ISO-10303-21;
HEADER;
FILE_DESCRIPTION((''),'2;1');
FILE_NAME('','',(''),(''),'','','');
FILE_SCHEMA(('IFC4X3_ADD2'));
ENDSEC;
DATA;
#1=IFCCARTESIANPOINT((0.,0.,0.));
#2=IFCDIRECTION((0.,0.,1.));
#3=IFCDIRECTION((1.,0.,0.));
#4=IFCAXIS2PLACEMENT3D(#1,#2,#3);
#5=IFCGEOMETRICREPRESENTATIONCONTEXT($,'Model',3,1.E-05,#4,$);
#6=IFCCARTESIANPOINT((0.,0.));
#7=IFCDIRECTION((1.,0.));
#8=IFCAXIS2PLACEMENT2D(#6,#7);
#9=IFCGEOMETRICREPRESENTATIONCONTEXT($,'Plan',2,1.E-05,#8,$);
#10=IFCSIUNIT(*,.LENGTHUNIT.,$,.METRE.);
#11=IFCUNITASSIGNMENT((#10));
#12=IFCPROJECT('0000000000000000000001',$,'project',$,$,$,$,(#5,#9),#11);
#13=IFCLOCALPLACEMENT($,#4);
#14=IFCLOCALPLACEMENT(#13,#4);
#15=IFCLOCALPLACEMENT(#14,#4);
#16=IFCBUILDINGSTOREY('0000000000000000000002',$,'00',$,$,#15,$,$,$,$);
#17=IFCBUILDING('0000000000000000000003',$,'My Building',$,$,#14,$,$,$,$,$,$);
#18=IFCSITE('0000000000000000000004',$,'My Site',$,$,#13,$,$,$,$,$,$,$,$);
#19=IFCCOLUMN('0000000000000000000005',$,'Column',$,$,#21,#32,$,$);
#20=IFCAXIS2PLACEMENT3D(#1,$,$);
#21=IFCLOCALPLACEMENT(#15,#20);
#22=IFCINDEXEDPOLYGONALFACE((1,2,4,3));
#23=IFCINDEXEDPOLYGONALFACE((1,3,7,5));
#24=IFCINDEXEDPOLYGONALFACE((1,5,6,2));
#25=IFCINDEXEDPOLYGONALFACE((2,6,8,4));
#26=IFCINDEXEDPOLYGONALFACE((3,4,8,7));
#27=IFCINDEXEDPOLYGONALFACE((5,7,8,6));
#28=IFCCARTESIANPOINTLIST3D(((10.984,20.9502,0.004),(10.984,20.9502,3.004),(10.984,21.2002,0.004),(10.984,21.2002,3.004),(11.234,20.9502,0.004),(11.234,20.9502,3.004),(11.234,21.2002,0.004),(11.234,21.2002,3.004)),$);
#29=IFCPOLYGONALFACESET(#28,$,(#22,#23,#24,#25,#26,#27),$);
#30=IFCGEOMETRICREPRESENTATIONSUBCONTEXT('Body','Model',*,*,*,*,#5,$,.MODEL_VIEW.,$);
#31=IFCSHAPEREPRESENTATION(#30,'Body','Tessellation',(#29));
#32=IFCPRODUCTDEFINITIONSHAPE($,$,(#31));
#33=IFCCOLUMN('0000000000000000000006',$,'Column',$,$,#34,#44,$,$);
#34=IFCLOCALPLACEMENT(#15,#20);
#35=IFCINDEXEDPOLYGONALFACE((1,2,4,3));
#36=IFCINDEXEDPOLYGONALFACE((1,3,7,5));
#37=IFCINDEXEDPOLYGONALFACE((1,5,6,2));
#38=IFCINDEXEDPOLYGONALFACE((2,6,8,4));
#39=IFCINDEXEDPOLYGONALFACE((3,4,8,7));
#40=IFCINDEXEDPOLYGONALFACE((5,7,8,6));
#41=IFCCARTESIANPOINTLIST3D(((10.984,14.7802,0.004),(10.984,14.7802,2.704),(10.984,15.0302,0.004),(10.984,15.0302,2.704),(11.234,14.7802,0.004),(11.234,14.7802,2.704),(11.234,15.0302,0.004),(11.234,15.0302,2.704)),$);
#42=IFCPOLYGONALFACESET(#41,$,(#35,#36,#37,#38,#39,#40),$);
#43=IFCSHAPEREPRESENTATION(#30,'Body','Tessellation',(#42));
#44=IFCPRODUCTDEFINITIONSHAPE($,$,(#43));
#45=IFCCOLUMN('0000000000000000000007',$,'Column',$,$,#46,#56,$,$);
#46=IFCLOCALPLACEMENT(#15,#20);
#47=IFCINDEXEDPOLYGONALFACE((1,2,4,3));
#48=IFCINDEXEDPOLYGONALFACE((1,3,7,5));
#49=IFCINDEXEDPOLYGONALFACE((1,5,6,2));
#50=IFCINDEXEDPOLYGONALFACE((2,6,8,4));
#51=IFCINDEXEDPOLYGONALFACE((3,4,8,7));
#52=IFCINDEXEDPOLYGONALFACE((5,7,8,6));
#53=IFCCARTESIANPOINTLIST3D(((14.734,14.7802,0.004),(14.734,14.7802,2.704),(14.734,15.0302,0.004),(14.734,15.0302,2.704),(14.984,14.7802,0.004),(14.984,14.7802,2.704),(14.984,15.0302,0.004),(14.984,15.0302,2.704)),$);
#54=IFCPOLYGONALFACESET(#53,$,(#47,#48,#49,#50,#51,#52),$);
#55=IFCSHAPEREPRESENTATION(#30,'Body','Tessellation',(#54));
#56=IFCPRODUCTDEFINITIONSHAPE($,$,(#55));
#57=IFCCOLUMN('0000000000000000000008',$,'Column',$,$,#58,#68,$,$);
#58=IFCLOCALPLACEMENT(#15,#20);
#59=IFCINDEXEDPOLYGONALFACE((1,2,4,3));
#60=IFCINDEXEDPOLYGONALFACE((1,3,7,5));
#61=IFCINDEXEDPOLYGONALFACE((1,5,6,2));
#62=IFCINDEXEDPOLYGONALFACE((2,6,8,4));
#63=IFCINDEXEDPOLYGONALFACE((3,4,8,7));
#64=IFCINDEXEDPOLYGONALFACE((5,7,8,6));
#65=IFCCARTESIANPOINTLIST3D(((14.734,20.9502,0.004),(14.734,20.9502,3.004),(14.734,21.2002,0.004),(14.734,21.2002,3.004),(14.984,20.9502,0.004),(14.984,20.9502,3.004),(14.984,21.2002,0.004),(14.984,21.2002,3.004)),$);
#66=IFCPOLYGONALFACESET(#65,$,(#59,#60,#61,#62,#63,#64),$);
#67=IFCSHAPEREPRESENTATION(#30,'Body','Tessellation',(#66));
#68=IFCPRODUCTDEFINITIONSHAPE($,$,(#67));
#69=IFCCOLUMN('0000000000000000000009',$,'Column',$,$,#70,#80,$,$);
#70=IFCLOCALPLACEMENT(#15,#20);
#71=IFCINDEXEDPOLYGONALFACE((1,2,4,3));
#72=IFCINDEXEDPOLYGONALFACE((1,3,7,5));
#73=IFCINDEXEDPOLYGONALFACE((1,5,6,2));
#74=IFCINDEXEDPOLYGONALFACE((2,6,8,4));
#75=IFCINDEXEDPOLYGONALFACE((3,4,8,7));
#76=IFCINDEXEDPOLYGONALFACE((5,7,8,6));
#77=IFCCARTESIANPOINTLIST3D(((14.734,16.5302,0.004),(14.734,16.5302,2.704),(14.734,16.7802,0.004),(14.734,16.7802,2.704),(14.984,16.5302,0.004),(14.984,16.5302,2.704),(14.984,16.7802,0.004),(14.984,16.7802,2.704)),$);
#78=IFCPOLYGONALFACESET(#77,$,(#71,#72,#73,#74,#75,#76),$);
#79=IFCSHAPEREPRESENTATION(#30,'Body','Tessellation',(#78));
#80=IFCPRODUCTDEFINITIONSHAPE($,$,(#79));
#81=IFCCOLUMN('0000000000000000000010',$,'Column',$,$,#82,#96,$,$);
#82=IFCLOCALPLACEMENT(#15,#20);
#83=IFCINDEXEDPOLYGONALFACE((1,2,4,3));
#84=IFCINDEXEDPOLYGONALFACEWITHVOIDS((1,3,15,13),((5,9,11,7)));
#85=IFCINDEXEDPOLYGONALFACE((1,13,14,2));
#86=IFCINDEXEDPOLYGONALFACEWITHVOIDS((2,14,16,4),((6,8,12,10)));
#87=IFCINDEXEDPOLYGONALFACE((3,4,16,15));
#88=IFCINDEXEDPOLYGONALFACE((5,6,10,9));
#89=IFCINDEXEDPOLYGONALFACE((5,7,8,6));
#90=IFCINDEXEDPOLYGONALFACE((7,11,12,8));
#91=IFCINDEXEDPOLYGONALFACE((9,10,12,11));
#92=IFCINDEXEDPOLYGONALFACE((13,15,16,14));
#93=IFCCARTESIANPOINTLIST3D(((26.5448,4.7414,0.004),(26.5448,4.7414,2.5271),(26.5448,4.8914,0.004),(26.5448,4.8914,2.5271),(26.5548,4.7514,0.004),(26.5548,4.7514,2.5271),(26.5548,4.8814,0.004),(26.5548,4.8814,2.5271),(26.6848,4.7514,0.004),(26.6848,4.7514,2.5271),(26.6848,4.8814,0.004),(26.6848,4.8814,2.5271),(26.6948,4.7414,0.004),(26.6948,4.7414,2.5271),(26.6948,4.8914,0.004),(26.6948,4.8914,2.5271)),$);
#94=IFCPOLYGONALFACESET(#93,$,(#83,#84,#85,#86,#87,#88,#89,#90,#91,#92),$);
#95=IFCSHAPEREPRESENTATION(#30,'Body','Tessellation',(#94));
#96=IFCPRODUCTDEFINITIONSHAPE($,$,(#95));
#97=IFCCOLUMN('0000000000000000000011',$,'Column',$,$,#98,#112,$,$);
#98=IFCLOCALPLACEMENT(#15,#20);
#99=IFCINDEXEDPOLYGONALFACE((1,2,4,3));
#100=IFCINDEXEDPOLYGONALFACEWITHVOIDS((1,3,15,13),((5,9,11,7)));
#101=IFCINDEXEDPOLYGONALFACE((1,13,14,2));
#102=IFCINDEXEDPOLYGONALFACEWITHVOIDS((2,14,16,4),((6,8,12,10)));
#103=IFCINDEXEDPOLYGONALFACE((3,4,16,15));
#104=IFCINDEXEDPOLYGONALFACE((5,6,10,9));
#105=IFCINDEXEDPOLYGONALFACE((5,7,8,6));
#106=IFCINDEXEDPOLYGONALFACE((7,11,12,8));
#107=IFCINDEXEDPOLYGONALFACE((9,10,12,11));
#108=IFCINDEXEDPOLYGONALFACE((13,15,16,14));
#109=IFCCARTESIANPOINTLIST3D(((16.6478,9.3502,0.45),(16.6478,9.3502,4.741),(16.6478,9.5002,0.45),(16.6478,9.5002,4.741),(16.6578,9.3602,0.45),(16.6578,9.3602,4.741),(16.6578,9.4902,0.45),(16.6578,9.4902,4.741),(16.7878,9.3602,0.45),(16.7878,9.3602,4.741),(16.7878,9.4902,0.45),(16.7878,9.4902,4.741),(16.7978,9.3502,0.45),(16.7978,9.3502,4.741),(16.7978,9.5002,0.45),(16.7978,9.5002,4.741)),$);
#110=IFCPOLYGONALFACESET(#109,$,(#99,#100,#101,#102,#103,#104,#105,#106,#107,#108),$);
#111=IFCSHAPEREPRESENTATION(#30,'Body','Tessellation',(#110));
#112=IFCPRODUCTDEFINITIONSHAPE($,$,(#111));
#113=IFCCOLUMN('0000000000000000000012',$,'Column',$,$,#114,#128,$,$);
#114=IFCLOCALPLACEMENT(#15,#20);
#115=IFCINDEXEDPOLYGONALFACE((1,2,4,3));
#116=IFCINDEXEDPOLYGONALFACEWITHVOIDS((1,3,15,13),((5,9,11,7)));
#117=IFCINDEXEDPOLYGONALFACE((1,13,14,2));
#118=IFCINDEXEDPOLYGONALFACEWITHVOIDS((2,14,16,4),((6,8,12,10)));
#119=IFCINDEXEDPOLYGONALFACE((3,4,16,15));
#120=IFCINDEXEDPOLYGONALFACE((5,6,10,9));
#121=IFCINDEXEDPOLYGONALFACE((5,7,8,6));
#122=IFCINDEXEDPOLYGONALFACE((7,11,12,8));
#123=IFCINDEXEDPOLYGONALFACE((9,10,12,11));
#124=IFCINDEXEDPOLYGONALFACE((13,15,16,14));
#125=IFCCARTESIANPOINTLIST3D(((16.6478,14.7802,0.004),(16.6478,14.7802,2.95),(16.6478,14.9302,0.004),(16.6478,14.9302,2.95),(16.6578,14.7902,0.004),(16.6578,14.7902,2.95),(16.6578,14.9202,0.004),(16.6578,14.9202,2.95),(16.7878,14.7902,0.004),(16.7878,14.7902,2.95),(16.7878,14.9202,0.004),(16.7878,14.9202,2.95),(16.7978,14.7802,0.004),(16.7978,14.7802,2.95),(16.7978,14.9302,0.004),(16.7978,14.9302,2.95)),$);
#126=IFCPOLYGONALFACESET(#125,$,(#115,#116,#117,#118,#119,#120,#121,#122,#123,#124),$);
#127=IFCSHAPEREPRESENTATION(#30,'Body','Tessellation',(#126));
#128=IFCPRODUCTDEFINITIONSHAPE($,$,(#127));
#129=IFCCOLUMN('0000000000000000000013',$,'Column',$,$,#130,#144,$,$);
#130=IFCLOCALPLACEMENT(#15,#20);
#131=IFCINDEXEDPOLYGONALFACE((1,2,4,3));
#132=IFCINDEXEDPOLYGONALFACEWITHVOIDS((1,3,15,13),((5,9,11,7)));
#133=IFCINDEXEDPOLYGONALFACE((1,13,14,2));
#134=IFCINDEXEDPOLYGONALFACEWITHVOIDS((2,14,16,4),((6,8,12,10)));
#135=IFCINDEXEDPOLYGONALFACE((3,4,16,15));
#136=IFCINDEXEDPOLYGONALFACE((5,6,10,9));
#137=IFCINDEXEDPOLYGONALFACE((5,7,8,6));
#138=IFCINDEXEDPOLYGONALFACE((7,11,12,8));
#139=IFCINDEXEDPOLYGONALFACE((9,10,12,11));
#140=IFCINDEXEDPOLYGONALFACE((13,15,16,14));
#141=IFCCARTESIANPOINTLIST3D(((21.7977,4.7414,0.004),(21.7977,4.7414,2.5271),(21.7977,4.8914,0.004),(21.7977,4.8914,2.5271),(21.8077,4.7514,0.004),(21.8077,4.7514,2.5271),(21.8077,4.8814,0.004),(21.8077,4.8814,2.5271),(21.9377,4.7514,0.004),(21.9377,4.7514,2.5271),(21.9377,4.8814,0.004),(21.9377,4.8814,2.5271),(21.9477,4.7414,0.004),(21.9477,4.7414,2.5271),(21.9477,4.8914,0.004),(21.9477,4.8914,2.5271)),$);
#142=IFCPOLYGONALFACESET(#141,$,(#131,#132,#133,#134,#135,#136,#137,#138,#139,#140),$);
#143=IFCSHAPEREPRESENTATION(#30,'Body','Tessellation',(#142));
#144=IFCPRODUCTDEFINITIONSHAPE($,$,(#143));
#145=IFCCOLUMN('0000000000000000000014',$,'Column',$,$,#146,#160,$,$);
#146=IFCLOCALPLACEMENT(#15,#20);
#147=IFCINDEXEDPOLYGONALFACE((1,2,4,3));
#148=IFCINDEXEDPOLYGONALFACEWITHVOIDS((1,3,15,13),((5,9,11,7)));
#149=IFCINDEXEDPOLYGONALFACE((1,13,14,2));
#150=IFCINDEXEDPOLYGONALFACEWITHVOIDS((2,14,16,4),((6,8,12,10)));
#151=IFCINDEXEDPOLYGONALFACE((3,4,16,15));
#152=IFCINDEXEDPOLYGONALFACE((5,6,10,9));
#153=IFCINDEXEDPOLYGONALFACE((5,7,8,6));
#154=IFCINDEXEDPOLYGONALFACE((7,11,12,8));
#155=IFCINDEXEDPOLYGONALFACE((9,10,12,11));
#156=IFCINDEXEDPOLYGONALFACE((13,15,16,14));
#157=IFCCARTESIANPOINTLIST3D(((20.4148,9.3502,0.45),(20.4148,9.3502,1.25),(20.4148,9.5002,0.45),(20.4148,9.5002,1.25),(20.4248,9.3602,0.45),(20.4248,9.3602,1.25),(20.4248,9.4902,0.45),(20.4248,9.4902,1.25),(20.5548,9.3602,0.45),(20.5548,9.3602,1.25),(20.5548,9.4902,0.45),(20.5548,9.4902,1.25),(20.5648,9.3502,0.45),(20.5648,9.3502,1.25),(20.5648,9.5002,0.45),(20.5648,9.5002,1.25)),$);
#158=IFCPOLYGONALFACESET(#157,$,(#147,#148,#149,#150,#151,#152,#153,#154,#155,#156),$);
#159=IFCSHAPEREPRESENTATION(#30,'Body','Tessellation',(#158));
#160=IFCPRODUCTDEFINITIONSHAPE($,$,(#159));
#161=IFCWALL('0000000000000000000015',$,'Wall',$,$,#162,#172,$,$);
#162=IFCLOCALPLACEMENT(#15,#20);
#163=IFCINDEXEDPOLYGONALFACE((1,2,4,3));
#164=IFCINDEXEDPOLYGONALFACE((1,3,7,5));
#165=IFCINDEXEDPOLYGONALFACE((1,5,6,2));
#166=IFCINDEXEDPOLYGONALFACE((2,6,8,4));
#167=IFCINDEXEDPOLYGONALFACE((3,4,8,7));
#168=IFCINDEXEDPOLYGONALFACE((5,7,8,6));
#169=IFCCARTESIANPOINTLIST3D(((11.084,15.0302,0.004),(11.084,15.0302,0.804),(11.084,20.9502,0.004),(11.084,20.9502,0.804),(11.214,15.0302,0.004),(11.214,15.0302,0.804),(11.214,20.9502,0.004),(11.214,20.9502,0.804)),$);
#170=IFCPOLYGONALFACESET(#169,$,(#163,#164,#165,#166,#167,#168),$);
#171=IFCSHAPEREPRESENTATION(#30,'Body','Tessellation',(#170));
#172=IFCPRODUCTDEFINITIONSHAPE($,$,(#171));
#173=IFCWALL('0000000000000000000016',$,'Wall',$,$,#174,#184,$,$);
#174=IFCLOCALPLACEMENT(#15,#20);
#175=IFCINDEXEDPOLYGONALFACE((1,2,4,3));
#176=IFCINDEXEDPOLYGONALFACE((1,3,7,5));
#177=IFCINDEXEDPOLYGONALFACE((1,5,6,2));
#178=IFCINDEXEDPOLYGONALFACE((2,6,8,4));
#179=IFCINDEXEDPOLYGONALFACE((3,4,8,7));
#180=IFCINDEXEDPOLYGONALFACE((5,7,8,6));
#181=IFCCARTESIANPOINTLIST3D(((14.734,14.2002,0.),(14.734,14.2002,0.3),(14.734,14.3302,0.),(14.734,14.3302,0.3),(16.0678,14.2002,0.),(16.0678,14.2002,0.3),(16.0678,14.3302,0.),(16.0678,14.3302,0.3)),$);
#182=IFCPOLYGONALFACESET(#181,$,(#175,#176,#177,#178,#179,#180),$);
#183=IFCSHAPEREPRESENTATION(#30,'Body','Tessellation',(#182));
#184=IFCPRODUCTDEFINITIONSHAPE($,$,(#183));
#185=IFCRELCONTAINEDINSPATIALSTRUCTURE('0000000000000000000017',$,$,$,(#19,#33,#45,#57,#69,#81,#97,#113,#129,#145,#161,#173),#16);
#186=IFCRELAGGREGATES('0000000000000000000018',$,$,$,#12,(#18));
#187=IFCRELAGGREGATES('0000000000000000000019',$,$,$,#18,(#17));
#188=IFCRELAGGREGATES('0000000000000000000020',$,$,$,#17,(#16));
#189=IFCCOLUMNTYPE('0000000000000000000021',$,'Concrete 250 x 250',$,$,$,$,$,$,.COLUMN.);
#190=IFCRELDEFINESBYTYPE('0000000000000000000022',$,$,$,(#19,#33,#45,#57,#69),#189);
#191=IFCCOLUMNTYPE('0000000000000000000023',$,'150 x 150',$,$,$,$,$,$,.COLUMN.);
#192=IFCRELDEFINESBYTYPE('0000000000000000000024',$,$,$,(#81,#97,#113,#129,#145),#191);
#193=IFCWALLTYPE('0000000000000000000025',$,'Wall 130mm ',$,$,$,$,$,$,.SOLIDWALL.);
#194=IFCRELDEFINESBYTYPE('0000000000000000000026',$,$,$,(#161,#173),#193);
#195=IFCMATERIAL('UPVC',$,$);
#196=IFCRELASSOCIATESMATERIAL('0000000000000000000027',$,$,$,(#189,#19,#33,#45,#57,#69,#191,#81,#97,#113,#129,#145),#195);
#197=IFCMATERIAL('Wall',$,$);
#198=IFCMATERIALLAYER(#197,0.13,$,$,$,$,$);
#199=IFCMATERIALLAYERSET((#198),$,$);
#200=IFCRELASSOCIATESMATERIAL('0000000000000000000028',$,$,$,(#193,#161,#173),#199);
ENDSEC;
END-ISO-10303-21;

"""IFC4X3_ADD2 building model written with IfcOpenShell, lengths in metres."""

from ifc_helpers import new_model, si_unit, frame, origin_with_axes, origin_2d_with_axis, place, context, subcontext, project, spatial, indexed_curve, rectangle, hollow_rectangle, outline, extrude, material, layer, layer_set, layer_usage, material_profile, profile_set, profile_usage, type_object, element, save


model = new_model("IFC4X3_ADD2")

# Units and contexts
model_context = context("Model", 3, precision=1e-05, world=origin_with_axes())
plan_context = context("Plan", 2, precision=1e-05, world=origin_2d_with_axis())
body_context = subcontext(model_context, "Body", "Model", "MODEL_VIEW")
ifc_project = project(units=[si_unit("LENGTHUNIT", "METRE")], contexts=[model_context, plan_context])

# Site, building, storey
site_placement = place(None, origin_with_axes())
site = spatial("IfcSite", under=ifc_project, at=site_placement, Name="My Site")
building_placement = place(site_placement, origin_with_axes())
building = spatial("IfcBuilding", under=site, at=building_placement, Name="My Building")
storey_placement = place(building_placement, origin_with_axes())
storey = spatial("IfcBuildingStorey", under=building, at=storey_placement, Name="00")

# Columns
ifc_material_1 = material(Name="UPVC")
ifc_material_profile_1 = material_profile(ifc_material_1, rectangle(XDim=0.25, YDim=0.25))
ifc_profile_set_1 = profile_set([ifc_material_profile_1])
ifc_profile_usage_1 = profile_usage(ifc_profile_set_1, cardinal=5)
column_type_1 = type_object("IfcColumnType", Name="Concrete 250 x 250", PredefinedType="COLUMN", material=ifc_profile_set_1)
column_1_placement = place(storey_placement, frame((11.109, 21.0752, 0.004), z_axis=(0.0, 0.0, 1.0), x_axis=(1.0, 0.0, 0.0)))
element("IfcColumn", 1, at=column_1_placement, inside=storey, type_object=column_type_1, material=ifc_profile_usage_1, Name="Column", context=body_context, shape_type="SweptSolid", body=[
    extrude(rectangle(XDim=0.25, YDim=0.25), origin_with_axes(), (0.0, 0.0, 1.0), 3.0),
])
ifc_profile_usage_2 = profile_usage(ifc_profile_set_1, cardinal=5)
column_2_placement = place(storey_placement, frame((11.109, 14.9052, 0.004), z_axis=(0.0, 0.0, 1.0), x_axis=(1.0, 0.0, 0.0)))
element("IfcColumn", 2, at=column_2_placement, inside=storey, type_object=column_type_1, material=ifc_profile_usage_2, Name="Column", context=body_context, shape_type="SweptSolid", body=[
    extrude(rectangle(XDim=0.25, YDim=0.25), origin_with_axes(), (0.0, 0.0, 1.0), 2.7),
])
ifc_profile_usage_3 = profile_usage(ifc_profile_set_1, cardinal=5)
column_3_placement = place(storey_placement, frame((14.859, 14.9052, 0.004), z_axis=(0.0, 0.0, 1.0), x_axis=(1.0, 0.0, 0.0)))
element("IfcColumn", 3, at=column_3_placement, inside=storey, type_object=column_type_1, material=ifc_profile_usage_3, Name="Column", context=body_context, shape_type="SweptSolid", body=[
    extrude(rectangle(XDim=0.25, YDim=0.25), origin_with_axes(), (0.0, 0.0, 1.0), 2.7),
])
ifc_profile_usage_4 = profile_usage(ifc_profile_set_1, cardinal=5)
column_4_placement = place(storey_placement, frame((14.859, 21.0752, 0.004), z_axis=(0.0, 0.0, 1.0), x_axis=(1.0, 0.0, 0.0)))
element("IfcColumn", 4, at=column_4_placement, inside=storey, type_object=column_type_1, material=ifc_profile_usage_4, Name="Column", context=body_context, shape_type="SweptSolid", body=[
    extrude(rectangle(XDim=0.25, YDim=0.25), origin_with_axes(), (0.0, 0.0, 1.0), 3.0),
])
ifc_profile_usage_5 = profile_usage(ifc_profile_set_1, cardinal=5)
column_5_placement = place(storey_placement, frame((14.859, 16.6552, 0.004), z_axis=(0.0, 0.0, 1.0), x_axis=(1.0, 0.0, 0.0)))
element("IfcColumn", 5, at=column_5_placement, inside=storey, type_object=column_type_1, material=ifc_profile_usage_5, Name="Column", context=body_context, shape_type="SweptSolid", body=[
    extrude(rectangle(XDim=0.25, YDim=0.25), origin_with_axes(), (0.0, 0.0, 1.0), 2.7),
])
ifc_material_profile_2 = material_profile(ifc_material_1, hollow_rectangle(XDim=0.15, YDim=0.15, WallThickness=0.01))
ifc_profile_set_2 = profile_set([ifc_material_profile_2])
ifc_profile_usage_6 = profile_usage(ifc_profile_set_2, cardinal=5)
column_type_2 = type_object("IfcColumnType", Name="150 x 150", PredefinedType="COLUMN", material=ifc_profile_set_2)
column_6_placement = place(storey_placement, frame((26.6198, 4.8164, 0.004), z_axis=(0.0, 0.0, 1.0), x_axis=(1.0, 0.0, 0.0)))
element("IfcColumn", 6, at=column_6_placement, inside=storey, type_object=column_type_2, material=ifc_profile_usage_6, Name="Column", context=body_context, shape_type="SweptSolid", body=[
    extrude(hollow_rectangle(XDim=0.15, YDim=0.15, WallThickness=0.01), origin_with_axes(), (0.0, 0.0, 1.0), 2.5231),
])
ifc_profile_usage_7 = profile_usage(ifc_profile_set_2, cardinal=5)
column_7_placement = place(storey_placement, frame((16.7228, 9.4252, 0.45), z_axis=(0.0, 0.0, 1.0), x_axis=(1.0, 0.0, 0.0)))
element("IfcColumn", 7, at=column_7_placement, inside=storey, type_object=column_type_2, material=ifc_profile_usage_7, Name="Column", context=body_context, shape_type="SweptSolid", body=[
    extrude(hollow_rectangle(XDim=0.15, YDim=0.15, WallThickness=0.01), origin_with_axes(), (0.0, 0.0, 1.0), 4.291),
])
ifc_profile_usage_8 = profile_usage(ifc_profile_set_2, cardinal=5)
column_8_placement = place(storey_placement, frame((16.7228, 14.8552, 0.004), z_axis=(0.0, 0.0, 1.0), x_axis=(1.0, 0.0, 0.0)))
element("IfcColumn", 8, at=column_8_placement, inside=storey, type_object=column_type_2, material=ifc_profile_usage_8, Name="Column", context=body_context, shape_type="SweptSolid", body=[
    extrude(hollow_rectangle(XDim=0.15, YDim=0.15, WallThickness=0.01), origin_with_axes(), (0.0, 0.0, 1.0), 2.946),
])
ifc_profile_usage_9 = profile_usage(ifc_profile_set_2, cardinal=5)
column_9_placement = place(storey_placement, frame((21.8727, 4.8164, 0.004), z_axis=(0.0, 0.0, 1.0), x_axis=(1.0, 0.0, 0.0)))
element("IfcColumn", 9, at=column_9_placement, inside=storey, type_object=column_type_2, material=ifc_profile_usage_9, Name="Column", context=body_context, shape_type="SweptSolid", body=[
    extrude(hollow_rectangle(XDim=0.15, YDim=0.15, WallThickness=0.01), origin_with_axes(), (0.0, 0.0, 1.0), 2.5231),
])
ifc_profile_usage_10 = profile_usage(ifc_profile_set_2, cardinal=5)
column_10_placement = place(storey_placement, frame((20.4898, 9.4252, 0.45), z_axis=(0.0, 0.0, 1.0), x_axis=(1.0, 0.0, 0.0)))
element("IfcColumn", 10, at=column_10_placement, inside=storey, type_object=column_type_2, material=ifc_profile_usage_10, Name="Column", context=body_context, shape_type="SweptSolid", body=[
    extrude(hollow_rectangle(XDim=0.15, YDim=0.15, WallThickness=0.01), origin_with_axes(), (0.0, 0.0, 1.0), 0.8),
])

# Walls
ifc_material_2 = material(Name="Wall")
ifc_layer_1 = layer(ifc_material_2, 0.13)
ifc_layer_set_1 = layer_set([ifc_layer_1])
ifc_layer_usage_1 = layer_usage(ifc_layer_set_1, "AXIS2", "POSITIVE", 0.0)
wall_type_1 = type_object("IfcWallType", Name="Wall 130mm ", PredefinedType="SOLIDWALL", material=ifc_layer_set_1)
wall_1_placement = place(storey_placement, frame((11.214, 15.0302, 0.004), z_axis=(0.0, 0.0, 1.0), x_axis=(0.000001, 1.0, 0.0)))
element("IfcWall", 11, at=wall_1_placement, inside=storey, type_object=wall_type_1, material=ifc_layer_usage_1, Name="Wall", context=body_context, shape_type="SweptSolid", body=[
    extrude(outline(indexed_curve([(0.0, 0.0), (0.0, 0.13), (5.92, 0.13), (5.92, 0.0), (0.0, 0.0)], self_intersect=False)), origin_with_axes(), (0.0, 0.0, 1.0), 0.8),
])
ifc_layer_usage_2 = layer_usage(ifc_layer_set_1, "AXIS2", "POSITIVE", 0.0)
wall_2_placement = place(storey_placement, frame((14.734, 14.2002, 0.0), z_axis=(0.0, 0.0, 1.0), x_axis=(1.0, 0.0, 0.0)))
element("IfcWall", 12, at=wall_2_placement, inside=storey, type_object=wall_type_1, material=ifc_layer_usage_2, Name="Wall", context=body_context, shape_type="SweptSolid", body=[
    extrude(outline(indexed_curve([(0.0, 0.0), (0.0, 0.13), (1.3338, 0.13), (1.3338, 0.0), (0.0, 0.0)], self_intersect=False)), origin_with_axes(), (0.0, 0.0, 1.0), 0.3),
])

save(model, "model.ifc")
